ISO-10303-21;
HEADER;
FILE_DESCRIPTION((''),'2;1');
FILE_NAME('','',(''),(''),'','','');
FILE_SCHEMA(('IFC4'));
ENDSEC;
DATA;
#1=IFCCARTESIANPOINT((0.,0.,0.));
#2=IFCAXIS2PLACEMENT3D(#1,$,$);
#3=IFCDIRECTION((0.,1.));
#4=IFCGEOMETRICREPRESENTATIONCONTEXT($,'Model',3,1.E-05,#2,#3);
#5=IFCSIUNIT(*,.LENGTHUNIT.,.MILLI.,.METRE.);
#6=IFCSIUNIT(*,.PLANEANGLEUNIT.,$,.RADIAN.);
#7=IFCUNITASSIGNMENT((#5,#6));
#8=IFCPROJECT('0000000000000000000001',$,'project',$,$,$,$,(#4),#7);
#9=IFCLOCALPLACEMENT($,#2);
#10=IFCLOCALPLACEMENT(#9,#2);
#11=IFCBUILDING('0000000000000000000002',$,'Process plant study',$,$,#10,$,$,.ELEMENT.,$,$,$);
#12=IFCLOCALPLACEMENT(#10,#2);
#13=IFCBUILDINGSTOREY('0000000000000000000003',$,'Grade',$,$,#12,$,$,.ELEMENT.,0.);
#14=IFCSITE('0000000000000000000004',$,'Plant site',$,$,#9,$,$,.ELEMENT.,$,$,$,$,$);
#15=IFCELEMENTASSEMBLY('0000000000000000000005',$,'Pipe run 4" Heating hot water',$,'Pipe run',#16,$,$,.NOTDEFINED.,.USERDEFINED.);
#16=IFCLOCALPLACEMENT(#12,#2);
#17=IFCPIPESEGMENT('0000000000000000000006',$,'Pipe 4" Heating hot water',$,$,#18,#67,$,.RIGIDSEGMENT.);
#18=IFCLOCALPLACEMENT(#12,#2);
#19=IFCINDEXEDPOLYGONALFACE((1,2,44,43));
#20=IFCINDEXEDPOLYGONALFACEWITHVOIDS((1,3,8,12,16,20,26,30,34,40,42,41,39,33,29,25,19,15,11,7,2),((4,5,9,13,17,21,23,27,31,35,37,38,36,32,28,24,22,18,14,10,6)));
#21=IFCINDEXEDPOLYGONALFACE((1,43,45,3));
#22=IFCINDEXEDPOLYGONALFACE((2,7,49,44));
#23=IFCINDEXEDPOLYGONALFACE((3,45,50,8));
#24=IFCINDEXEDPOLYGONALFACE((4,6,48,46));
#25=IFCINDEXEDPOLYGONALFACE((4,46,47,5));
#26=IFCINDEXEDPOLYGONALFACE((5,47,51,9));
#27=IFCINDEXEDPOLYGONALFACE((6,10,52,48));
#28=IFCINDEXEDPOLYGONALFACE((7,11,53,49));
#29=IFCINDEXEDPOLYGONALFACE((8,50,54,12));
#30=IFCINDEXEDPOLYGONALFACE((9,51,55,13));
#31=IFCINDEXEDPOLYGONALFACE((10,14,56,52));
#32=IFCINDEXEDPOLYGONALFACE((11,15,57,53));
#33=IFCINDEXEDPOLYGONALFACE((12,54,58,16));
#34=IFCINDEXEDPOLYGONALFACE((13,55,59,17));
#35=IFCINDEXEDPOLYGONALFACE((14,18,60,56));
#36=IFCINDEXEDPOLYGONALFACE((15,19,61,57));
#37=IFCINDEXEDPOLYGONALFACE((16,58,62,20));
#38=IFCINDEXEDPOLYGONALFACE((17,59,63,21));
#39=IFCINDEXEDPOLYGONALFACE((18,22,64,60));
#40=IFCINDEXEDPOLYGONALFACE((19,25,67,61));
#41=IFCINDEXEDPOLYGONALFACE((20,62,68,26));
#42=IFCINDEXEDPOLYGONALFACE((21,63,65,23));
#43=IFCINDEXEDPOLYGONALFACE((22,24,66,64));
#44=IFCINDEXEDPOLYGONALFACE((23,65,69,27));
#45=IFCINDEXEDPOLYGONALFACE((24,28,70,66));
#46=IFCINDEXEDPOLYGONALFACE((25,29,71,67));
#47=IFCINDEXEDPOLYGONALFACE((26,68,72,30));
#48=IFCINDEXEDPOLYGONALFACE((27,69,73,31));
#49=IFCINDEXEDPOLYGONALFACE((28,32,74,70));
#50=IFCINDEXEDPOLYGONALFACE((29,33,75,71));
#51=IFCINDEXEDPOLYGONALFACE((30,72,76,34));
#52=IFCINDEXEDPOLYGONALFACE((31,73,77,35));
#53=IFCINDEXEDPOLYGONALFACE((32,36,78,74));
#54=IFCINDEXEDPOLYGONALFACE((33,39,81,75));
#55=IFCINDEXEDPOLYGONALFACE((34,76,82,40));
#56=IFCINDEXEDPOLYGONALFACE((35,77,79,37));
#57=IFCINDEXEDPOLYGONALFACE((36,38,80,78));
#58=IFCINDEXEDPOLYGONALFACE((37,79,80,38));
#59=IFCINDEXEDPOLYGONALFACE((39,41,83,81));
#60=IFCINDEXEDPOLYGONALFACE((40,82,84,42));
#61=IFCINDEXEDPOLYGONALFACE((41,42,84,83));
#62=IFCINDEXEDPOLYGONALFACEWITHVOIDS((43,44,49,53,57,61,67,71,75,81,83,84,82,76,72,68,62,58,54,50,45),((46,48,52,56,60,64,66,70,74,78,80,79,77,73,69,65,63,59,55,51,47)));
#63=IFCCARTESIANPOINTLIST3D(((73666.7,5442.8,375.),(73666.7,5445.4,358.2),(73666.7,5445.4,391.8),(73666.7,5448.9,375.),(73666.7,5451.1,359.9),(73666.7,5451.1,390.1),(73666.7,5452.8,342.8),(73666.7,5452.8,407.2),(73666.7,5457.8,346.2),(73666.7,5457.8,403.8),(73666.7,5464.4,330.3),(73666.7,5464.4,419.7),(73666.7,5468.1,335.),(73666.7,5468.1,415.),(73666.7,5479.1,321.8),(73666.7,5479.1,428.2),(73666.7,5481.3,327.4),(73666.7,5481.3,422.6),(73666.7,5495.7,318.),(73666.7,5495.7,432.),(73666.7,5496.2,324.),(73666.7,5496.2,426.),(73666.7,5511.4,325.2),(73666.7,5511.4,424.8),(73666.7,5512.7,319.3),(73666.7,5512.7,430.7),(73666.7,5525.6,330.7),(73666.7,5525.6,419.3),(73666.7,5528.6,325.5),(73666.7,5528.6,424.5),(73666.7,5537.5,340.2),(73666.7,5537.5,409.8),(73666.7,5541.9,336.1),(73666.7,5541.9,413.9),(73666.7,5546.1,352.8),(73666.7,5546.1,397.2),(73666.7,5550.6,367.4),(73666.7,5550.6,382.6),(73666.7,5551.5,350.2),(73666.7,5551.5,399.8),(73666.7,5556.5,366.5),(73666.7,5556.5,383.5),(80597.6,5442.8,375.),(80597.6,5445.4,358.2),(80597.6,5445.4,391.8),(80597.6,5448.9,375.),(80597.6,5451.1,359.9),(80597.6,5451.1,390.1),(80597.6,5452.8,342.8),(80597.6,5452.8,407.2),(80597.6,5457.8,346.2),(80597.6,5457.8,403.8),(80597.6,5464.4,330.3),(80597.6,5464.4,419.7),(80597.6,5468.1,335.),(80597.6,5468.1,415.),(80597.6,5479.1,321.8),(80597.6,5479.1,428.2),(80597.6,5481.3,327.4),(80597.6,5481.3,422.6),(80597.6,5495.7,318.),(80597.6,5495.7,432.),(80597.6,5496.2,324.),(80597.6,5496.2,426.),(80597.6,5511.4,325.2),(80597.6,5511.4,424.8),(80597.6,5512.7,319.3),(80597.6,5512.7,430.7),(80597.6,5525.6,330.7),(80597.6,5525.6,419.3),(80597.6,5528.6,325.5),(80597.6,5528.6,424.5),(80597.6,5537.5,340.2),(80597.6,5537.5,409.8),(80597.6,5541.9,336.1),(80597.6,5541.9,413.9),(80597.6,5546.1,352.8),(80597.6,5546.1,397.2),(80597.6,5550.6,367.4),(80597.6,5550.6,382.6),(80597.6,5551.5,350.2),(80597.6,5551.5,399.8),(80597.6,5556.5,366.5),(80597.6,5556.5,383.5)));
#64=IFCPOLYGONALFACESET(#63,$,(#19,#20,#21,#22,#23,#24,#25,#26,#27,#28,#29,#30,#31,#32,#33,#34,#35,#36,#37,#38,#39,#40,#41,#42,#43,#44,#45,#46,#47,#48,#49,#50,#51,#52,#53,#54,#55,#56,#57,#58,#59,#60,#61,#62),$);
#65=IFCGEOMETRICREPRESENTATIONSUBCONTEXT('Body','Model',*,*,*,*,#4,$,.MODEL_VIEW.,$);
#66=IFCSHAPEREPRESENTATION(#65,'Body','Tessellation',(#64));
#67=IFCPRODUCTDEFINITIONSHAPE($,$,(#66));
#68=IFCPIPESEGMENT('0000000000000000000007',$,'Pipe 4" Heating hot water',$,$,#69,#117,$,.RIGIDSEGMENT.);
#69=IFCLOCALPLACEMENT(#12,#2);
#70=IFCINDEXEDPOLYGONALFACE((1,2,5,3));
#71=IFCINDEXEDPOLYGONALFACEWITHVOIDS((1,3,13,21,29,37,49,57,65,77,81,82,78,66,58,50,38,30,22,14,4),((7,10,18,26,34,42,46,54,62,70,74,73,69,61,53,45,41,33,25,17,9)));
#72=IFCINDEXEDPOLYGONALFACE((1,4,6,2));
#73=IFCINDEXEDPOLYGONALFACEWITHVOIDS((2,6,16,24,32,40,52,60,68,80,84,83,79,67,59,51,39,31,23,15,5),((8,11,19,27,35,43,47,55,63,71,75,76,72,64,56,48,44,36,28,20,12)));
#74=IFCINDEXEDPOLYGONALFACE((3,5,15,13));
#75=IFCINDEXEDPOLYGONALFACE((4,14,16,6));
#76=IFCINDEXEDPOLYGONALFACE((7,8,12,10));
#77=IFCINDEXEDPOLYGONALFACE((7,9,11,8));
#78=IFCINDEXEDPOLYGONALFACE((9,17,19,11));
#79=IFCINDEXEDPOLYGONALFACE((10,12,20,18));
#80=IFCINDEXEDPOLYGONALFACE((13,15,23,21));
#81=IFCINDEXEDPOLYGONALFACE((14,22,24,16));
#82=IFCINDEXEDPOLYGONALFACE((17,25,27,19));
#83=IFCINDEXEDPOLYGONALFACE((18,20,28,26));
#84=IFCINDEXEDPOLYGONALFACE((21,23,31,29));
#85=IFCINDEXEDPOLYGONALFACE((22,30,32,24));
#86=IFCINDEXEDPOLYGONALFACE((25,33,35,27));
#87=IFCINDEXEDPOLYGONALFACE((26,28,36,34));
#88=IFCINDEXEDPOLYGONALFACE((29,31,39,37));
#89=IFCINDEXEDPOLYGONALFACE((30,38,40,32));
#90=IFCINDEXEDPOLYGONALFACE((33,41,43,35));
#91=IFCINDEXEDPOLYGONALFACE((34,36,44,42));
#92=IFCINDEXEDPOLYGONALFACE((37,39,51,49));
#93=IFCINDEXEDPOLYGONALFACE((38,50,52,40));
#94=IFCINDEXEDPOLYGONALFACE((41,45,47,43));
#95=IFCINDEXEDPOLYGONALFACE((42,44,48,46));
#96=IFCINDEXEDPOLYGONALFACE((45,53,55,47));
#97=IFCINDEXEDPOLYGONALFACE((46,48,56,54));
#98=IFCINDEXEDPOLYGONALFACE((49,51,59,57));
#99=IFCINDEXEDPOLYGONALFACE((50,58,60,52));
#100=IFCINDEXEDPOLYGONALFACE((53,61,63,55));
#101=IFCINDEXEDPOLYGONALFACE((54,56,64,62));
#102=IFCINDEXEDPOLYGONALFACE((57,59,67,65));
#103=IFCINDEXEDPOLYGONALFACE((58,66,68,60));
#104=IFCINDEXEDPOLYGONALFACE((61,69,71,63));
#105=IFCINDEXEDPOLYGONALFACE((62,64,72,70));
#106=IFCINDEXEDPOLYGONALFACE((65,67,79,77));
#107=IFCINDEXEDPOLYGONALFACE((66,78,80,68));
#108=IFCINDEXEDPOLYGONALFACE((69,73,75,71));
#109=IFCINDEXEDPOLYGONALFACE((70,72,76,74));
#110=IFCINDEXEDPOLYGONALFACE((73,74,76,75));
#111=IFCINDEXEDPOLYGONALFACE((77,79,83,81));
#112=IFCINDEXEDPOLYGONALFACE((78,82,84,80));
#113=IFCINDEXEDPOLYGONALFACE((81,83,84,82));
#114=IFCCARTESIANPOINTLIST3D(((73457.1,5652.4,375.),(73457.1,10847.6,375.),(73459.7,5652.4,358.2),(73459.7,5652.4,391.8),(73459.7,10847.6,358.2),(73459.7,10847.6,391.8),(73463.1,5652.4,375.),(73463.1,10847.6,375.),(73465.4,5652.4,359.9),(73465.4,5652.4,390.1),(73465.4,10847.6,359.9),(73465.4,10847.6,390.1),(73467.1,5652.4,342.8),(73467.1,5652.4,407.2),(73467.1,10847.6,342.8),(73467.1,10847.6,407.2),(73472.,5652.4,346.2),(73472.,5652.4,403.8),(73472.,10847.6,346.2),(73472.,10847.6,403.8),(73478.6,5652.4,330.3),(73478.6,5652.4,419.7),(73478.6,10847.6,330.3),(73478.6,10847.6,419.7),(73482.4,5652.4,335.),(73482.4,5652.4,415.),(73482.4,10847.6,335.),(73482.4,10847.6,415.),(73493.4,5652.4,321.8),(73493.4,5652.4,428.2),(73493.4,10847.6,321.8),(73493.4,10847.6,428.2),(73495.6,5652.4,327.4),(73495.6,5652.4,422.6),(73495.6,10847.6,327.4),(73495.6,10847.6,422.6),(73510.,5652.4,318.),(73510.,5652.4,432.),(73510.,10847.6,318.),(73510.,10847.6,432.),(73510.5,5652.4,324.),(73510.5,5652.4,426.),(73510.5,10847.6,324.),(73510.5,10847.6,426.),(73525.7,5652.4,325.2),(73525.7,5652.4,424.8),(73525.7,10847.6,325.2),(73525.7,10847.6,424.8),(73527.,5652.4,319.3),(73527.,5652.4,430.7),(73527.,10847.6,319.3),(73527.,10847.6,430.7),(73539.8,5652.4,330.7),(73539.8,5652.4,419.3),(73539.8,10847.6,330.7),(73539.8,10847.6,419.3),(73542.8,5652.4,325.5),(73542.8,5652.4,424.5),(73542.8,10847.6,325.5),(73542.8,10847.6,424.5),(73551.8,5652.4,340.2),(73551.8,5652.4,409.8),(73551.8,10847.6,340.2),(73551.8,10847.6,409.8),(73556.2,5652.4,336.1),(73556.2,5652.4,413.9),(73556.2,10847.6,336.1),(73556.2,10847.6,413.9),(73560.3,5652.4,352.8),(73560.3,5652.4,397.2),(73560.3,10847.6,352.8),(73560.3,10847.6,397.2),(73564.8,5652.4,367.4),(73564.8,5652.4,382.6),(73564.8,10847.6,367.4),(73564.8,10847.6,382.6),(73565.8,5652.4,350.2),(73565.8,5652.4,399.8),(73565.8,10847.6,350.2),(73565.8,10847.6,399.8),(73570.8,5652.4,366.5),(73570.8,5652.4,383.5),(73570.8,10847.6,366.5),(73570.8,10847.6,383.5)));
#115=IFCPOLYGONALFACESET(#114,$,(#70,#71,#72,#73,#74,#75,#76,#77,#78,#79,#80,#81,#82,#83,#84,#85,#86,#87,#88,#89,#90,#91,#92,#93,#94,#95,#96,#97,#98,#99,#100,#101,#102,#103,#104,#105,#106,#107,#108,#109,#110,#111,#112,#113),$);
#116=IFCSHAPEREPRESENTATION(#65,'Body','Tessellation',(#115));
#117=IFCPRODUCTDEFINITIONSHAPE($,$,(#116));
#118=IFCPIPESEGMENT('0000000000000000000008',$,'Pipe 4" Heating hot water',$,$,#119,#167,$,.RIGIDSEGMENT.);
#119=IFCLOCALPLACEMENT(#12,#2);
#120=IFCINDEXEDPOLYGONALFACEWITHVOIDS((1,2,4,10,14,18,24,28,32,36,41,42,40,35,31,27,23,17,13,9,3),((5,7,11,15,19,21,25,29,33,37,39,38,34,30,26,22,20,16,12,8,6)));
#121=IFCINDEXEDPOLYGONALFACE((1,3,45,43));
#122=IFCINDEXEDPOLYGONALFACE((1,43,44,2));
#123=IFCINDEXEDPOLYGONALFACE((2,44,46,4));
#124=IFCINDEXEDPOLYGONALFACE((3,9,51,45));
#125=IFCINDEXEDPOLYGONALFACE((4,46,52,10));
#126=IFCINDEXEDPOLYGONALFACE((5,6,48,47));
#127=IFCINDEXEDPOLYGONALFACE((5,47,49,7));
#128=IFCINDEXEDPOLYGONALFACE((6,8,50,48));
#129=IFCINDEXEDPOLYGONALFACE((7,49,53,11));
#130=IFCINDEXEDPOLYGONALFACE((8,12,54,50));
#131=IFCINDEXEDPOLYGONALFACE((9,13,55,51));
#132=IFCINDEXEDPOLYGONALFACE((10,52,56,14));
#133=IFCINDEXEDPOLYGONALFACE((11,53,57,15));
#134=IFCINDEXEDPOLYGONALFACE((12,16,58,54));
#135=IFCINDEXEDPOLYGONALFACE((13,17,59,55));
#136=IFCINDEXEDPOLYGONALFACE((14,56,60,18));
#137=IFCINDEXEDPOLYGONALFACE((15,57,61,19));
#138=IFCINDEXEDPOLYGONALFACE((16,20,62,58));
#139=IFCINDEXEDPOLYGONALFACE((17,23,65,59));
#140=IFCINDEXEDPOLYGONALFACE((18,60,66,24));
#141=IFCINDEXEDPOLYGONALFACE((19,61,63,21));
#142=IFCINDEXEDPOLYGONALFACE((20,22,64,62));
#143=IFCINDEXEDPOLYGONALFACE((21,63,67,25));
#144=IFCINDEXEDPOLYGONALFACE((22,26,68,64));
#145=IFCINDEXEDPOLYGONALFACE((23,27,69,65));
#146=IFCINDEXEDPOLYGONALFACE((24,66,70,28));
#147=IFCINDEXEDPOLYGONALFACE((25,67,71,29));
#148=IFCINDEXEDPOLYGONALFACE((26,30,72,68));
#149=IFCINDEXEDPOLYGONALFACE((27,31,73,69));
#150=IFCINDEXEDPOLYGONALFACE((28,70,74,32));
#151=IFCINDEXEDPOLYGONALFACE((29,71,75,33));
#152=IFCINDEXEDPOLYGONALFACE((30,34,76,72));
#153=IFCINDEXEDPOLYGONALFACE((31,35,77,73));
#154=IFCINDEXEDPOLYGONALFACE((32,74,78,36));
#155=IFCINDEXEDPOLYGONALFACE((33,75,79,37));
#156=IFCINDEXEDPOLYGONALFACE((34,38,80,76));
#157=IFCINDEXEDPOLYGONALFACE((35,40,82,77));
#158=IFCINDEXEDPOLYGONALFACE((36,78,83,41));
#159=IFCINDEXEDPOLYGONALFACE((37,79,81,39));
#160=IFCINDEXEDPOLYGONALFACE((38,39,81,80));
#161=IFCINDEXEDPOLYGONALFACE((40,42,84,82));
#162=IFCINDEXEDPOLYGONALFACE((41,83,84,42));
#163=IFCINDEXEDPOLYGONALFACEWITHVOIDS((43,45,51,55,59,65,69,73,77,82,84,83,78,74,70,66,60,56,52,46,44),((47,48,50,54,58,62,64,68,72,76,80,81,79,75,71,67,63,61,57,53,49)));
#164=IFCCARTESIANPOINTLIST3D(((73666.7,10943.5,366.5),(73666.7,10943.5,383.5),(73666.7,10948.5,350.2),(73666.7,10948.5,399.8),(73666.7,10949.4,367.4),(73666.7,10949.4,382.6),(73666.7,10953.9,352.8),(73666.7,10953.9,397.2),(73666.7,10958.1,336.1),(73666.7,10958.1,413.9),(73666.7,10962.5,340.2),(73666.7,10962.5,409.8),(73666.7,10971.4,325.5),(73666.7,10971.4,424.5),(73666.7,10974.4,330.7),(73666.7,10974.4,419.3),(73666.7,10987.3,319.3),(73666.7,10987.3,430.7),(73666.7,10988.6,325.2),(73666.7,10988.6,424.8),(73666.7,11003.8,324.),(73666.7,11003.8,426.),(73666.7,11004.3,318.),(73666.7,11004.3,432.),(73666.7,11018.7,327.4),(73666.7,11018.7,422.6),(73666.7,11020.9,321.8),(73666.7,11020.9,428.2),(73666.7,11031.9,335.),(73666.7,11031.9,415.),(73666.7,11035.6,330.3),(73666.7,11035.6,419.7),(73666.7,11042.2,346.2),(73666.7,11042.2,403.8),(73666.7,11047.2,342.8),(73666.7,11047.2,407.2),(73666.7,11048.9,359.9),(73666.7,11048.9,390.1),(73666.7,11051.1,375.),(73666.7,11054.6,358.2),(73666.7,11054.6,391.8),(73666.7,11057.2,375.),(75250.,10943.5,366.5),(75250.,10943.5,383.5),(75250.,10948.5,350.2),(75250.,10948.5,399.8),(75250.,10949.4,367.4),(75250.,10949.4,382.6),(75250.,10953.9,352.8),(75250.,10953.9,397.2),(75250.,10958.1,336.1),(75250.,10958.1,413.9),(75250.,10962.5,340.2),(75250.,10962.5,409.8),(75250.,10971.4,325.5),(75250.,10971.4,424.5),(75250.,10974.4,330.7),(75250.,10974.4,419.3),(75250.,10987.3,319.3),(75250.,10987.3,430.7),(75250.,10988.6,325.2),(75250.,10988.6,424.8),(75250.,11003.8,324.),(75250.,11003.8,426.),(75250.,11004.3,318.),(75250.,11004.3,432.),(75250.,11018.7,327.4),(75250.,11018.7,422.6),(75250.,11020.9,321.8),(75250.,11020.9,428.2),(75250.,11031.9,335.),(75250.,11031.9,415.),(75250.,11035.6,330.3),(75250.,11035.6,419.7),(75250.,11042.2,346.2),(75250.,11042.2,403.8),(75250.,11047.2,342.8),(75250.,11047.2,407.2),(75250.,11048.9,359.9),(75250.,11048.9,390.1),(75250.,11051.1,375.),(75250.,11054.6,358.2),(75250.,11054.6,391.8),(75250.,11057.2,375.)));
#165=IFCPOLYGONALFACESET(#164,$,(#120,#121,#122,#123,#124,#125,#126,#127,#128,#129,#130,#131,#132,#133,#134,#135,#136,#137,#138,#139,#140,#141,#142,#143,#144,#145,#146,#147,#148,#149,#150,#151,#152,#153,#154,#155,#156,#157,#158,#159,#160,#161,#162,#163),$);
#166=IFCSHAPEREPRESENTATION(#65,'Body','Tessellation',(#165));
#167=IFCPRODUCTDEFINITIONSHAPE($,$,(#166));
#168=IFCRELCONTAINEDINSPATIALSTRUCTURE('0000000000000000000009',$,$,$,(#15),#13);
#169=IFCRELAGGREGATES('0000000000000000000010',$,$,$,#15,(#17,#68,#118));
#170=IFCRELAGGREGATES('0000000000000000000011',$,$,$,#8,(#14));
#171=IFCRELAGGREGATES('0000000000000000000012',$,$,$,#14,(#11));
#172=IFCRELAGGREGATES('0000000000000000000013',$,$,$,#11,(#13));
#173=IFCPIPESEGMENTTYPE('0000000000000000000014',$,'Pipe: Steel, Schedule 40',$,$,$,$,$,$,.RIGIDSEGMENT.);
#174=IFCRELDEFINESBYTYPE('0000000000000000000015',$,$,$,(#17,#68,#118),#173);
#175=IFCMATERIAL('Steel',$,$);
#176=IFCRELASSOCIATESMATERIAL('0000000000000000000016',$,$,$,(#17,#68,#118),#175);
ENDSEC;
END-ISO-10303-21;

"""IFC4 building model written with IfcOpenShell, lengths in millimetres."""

from ifc_helpers import new_model, si_unit, direction, frame, origin, origin_with_axes, origin_2d, place, context, subcontext, project, spatial, hollow_circle, extrude, material, type_object, element, aggregate, save


model = new_model("IFC4")

# Units and contexts
model_context = context("Model", 3, precision=1e-05, world=origin(), true_north=direction((0.0, 1.0)))
body_context = subcontext(model_context, "Body", "Model", "MODEL_VIEW")
ifc_project = project(units=[si_unit("LENGTHUNIT", "METRE", prefix="MILLI"), si_unit("PLANEANGLEUNIT", "RADIAN")], contexts=[model_context])

# Site, building, storey
site_placement = place(None, origin())
site = spatial("IfcSite", under=ifc_project, at=site_placement, Name="Plant site", CompositionType="ELEMENT")
building_placement = place(site_placement, origin())
building = spatial("IfcBuilding", under=site, at=building_placement, Name="Process plant study", CompositionType="ELEMENT")
storey_placement = place(building_placement, origin())
storey = spatial("IfcBuildingStorey", under=building, at=storey_placement, Name="Grade", CompositionType="ELEMENT", Elevation=0.0)

# Element assembly, pipe segments
ifc_material = material(Name="Steel")
pipe_segment_type = type_object("IfcPipeSegmentType", Name="Pipe: Steel, Schedule 40", PredefinedType="RIGIDSEGMENT")
assembly_1_placement = place(storey_placement, origin_with_axes())
assembly_1 = element("IfcElementAssembly", 1, at=assembly_1_placement, inside=storey, Name="Pipe run 4\" Heating hot water", ObjectType="Pipe run", AssemblyPlace="NOTDEFINED", PredefinedType="USERDEFINED")
pipe_segment_1_placement = place(storey_placement, origin_with_axes())
pipe_segment_1 = element("IfcPipeSegment", 2, at=pipe_segment_1_placement, type_object=pipe_segment_type, material=ifc_material, Name="Pipe 4\" Heating hot water", PredefinedType="RIGIDSEGMENT", context=body_context, shape_type="SweptSolid", body=[
    extrude(hollow_circle(Radius=57.1, WallThickness=6.0, at=origin_2d()), frame((80597.6, 5500.0, 375.0), z_axis=(-1.0, 0.0, 0.0), x_axis=(0.0, -1.0, 0.0)), (0.0, 0.0, 1.0), 6930.9),
])
pipe_segment_2_placement = place(storey_placement, origin_with_axes())
pipe_segment_2 = element("IfcPipeSegment", 3, at=pipe_segment_2_placement, type_object=pipe_segment_type, material=ifc_material, Name="Pipe 4\" Heating hot water", PredefinedType="RIGIDSEGMENT", context=body_context, shape_type="SweptSolid", body=[
    extrude(hollow_circle(Radius=57.1, WallThickness=6.0, at=origin_2d()), frame((73514.3, 5652.4, 375.0), z_axis=(0.0, 1.0, 0.0), x_axis=(-1.0, 0.0, 0.0)), (0.0, 0.0, 1.0), 5195.2),
])
pipe_segment_3_placement = place(storey_placement, origin_with_axes())
pipe_segment_3 = element("IfcPipeSegment", 4, at=pipe_segment_3_placement, type_object=pipe_segment_type, material=ifc_material, Name="Pipe 4\" Heating hot water", PredefinedType="RIGIDSEGMENT", context=body_context, shape_type="SweptSolid", body=[
    extrude(hollow_circle(Radius=57.1, WallThickness=6.0, at=origin_2d()), frame((73666.7, 11000.0, 375.0), z_axis=(1.0, 0.0, 0.0), x_axis=(0.0, 1.0, 0.0)), (0.0, 0.0, 1.0), 1583.3),
])

aggregate(assembly_1, [pipe_segment_1, pipe_segment_2, pipe_segment_3])

save(model, "model.ifc")
